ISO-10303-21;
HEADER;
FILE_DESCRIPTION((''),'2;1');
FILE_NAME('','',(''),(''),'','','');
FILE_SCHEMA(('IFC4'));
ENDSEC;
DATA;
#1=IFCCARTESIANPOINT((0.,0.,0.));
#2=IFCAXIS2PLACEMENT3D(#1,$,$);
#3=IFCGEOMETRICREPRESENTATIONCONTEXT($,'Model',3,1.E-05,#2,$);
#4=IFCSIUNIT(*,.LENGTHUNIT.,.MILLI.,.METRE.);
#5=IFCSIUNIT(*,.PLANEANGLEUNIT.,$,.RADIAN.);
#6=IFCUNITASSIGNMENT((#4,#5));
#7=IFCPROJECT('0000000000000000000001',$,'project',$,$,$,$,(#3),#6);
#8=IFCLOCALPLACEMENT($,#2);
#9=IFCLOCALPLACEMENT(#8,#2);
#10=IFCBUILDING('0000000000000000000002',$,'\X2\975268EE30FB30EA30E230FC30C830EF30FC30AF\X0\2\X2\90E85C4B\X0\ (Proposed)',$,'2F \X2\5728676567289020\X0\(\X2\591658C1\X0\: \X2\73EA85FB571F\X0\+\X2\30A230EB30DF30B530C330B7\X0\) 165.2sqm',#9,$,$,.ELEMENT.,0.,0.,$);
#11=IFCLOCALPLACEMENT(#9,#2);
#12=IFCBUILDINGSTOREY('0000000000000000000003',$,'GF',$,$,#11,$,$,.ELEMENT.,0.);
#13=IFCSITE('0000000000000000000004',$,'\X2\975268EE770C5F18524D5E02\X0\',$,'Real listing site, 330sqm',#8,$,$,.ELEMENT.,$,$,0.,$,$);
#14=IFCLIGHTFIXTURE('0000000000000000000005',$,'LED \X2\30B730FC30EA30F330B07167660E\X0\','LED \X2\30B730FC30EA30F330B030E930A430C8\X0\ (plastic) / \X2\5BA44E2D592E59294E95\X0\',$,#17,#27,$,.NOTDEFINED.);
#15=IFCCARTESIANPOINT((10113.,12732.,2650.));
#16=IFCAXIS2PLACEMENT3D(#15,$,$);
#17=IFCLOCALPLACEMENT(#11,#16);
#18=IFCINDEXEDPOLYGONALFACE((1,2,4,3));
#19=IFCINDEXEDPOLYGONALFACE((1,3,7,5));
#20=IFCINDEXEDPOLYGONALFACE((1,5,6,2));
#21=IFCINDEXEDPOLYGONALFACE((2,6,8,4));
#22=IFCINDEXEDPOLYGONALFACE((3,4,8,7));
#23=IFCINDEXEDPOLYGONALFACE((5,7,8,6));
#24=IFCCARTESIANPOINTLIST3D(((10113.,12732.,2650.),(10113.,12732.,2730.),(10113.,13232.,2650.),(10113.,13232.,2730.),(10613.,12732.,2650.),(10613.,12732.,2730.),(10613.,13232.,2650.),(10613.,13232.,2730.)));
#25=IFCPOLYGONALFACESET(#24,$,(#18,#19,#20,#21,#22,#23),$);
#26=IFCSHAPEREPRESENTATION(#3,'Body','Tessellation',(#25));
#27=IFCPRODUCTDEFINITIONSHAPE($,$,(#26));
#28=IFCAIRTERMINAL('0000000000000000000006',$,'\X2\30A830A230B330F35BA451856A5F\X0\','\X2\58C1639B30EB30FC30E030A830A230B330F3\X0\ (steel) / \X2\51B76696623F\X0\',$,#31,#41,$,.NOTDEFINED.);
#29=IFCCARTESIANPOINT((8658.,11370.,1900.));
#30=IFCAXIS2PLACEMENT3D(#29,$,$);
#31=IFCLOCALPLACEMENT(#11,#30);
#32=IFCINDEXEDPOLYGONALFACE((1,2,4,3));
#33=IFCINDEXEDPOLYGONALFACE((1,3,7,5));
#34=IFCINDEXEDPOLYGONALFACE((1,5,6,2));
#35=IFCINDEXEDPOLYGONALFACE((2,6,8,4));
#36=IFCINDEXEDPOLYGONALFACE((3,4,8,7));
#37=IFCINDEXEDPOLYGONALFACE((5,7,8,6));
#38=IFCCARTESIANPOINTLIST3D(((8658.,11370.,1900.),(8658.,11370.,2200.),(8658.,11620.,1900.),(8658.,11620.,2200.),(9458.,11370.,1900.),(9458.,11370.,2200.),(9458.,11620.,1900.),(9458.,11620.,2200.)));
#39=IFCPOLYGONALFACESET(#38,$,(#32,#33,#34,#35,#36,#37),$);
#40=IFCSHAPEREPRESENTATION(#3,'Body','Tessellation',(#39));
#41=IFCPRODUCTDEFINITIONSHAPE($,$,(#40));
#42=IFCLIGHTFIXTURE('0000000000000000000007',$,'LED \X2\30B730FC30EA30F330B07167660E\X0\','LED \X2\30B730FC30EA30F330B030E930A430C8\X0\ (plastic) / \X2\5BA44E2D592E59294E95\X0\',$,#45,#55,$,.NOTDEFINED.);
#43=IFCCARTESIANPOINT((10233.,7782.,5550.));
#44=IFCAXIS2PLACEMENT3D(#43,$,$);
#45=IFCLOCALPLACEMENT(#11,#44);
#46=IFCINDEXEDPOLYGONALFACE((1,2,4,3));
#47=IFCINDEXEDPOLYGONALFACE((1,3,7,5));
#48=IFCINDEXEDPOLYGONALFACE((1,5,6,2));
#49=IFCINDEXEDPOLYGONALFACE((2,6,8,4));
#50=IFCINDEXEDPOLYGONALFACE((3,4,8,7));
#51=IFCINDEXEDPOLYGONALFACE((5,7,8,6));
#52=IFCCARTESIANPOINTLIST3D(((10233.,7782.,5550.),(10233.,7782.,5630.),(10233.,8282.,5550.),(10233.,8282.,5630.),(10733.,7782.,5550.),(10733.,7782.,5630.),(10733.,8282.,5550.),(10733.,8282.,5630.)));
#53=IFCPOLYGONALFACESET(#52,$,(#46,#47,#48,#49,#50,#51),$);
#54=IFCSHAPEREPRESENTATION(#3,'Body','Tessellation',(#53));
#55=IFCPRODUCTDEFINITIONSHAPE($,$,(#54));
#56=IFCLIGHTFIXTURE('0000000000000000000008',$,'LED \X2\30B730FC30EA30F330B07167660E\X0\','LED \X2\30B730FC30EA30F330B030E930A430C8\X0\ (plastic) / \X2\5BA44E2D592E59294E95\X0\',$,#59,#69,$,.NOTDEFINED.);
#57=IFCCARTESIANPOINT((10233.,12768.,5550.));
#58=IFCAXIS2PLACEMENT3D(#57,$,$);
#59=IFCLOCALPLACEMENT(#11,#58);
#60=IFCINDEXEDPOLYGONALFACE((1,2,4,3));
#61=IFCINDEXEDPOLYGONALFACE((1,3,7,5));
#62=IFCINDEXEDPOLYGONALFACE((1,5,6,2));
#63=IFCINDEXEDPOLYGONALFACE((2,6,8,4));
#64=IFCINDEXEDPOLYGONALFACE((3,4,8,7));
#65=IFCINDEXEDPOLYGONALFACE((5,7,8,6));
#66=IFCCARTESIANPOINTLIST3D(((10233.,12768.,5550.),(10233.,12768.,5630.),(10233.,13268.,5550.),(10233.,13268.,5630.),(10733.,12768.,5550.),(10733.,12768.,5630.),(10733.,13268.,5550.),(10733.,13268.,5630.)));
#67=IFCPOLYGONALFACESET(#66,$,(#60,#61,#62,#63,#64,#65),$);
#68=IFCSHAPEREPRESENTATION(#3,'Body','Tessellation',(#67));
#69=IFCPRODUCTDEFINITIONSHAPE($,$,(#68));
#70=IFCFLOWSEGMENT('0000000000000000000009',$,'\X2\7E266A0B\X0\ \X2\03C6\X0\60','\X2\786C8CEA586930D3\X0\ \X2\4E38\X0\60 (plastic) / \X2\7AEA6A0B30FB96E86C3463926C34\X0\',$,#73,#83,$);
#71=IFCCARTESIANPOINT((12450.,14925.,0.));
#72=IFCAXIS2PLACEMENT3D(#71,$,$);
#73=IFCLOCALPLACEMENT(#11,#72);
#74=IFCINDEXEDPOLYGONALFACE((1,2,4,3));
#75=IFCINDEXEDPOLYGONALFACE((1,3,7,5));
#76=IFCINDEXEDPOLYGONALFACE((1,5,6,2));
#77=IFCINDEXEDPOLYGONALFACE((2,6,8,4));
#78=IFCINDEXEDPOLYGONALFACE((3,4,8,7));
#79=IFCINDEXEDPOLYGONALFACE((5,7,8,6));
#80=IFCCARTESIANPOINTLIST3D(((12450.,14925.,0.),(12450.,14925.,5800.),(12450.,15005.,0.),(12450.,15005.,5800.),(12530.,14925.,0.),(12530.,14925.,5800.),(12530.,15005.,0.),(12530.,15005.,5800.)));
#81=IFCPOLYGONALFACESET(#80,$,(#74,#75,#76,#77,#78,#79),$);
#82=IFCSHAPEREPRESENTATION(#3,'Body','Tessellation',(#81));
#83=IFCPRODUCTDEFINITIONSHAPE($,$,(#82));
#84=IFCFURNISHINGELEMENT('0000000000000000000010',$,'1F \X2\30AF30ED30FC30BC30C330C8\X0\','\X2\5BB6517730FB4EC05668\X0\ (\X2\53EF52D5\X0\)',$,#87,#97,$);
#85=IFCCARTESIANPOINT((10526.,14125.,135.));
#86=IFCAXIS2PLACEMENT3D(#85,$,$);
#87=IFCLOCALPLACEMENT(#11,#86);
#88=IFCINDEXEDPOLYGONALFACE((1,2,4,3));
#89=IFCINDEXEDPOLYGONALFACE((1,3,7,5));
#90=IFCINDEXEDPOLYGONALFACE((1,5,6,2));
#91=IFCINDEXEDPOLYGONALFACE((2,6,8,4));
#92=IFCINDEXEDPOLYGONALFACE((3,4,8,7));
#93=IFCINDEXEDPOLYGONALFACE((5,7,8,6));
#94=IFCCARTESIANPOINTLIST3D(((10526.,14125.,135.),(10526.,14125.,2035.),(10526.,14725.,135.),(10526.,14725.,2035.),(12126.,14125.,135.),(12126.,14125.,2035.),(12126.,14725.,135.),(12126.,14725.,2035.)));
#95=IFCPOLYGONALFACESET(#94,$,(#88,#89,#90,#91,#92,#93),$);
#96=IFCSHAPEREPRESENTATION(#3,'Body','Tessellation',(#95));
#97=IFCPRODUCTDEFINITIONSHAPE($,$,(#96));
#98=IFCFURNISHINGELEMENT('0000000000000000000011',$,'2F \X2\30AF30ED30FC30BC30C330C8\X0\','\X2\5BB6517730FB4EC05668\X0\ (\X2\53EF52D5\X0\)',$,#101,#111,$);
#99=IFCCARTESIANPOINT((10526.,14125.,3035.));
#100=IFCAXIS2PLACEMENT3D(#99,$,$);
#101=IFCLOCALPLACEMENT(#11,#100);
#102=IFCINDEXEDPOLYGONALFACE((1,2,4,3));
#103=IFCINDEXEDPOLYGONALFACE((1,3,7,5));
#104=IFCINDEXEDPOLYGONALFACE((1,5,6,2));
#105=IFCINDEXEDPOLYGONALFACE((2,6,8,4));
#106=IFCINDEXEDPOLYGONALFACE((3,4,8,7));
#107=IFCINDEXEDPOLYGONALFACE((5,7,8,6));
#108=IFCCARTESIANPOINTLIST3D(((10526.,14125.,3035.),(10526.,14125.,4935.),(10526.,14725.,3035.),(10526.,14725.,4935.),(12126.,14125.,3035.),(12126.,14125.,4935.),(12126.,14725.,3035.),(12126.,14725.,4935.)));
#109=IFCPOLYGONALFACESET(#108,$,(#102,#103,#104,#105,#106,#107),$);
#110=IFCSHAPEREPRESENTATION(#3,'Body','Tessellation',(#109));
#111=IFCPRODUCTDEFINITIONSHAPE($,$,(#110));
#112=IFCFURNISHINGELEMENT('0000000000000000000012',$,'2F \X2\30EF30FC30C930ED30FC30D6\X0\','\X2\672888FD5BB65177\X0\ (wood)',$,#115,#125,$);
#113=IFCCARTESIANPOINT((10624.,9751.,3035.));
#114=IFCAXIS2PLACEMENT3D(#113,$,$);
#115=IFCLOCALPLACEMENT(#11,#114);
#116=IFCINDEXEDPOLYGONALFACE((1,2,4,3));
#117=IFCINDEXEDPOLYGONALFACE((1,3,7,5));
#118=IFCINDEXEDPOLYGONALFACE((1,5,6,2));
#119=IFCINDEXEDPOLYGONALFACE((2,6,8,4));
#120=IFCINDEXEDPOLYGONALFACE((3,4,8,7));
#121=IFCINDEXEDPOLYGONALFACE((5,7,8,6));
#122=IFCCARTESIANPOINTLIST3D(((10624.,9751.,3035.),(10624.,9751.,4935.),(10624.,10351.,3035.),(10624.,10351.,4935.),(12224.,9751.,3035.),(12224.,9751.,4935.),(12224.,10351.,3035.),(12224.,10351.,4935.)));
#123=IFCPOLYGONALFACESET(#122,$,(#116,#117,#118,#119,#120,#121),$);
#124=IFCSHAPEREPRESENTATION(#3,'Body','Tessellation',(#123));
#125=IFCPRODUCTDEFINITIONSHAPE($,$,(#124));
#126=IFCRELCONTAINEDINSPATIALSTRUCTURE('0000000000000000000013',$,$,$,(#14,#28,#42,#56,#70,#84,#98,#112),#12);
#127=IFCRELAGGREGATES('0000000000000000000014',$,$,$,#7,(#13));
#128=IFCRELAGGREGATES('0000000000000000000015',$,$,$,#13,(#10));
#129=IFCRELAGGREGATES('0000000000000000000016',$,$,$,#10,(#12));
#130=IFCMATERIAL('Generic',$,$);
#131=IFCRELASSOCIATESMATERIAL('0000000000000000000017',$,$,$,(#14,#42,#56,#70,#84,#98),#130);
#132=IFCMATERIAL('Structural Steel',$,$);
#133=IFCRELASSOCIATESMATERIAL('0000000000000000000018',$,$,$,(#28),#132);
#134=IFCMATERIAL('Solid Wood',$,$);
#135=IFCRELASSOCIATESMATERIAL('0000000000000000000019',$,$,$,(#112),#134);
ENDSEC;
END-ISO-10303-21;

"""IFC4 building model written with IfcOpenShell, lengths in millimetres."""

from ifc_helpers import new_model, si_unit, frame, frame_2d, origin, place, context, project, spatial, rectangle, extrude, material, element, save


model = new_model("IFC4")

# Units and contexts
model_context = context("Model", 3, precision=1e-05, world=origin())
ifc_project = project(units=[si_unit("LENGTHUNIT", "METRE", prefix="MILLI"), si_unit("PLANEANGLEUNIT", "RADIAN")], contexts=[model_context])

# Site, building, storey
site_placement = place(None, origin())
site = spatial("IfcSite", under=ifc_project, at=site_placement, Name="青森県弘前市", ObjectType="Real listing site, 330sqm", CompositionType="ELEMENT", RefElevation=0.0)
building_placement = place(site_placement, origin())
building = spatial("IfcBuilding", under=site, at=building_placement, Name="青森・リモートワーク2部屋 (Proposed)", ObjectType="2F 在来木造(外壁: 珪藻土+アルミサッシ) 165.2sqm", CompositionType="ELEMENT", ElevationOfRefHeight=0.0, ElevationOfTerrain=0.0)
storey_placement = place(building_placement, origin())
storey = spatial("IfcBuildingStorey", under=building, at=storey_placement, Name="GF", CompositionType="ELEMENT", Elevation=0.0)

# Shared definitions
ifc_material_1 = material(Name="Solid Wood")
ifc_material_2 = material(Name="Structural Steel")

# Shared definitions
ifc_material_3 = material(Name="Generic")

# Light fixture
light_fixture_1_placement = place(storey_placement, frame((10113.0, 12732.0, 2650.0)))
element("IfcLightFixture", 1, at=light_fixture_1_placement, inside=storey, material=ifc_material_3, Name="LED シーリング照明", Description="LED シーリングライト (plastic) / 室中央天井", PredefinedType="NOTDEFINED", context=model_context, shape_type="SweptSolid", body=[
    extrude(rectangle(XDim=500.0, YDim=500.0, at=frame_2d((250.0, 250.0))), frame((10113.0, 12732.0, 2650.0)), (0.0, 0.0, 1.0), 80.0),
])

# Air terminal
air_terminal_placement = place(storey_placement, frame((8658.0, 11370.0, 1900.0)))
element("IfcAirTerminal", 2, at=air_terminal_placement, inside=storey, material=ifc_material_2, Name="エアコン室内機", Description="壁掛ルームエアコン (steel) / 冷暖房", PredefinedType="NOTDEFINED", context=model_context, shape_type="SweptSolid", body=[
    extrude(rectangle(XDim=800.0, YDim=250.0, at=frame_2d((400.0, 125.0))), frame((8658.0, 11370.0, 1900.0)), (0.0, 0.0, 1.0), 300.0),
])

# Light fixtures
light_fixture_2_placement = place(storey_placement, frame((10233.0, 7782.0, 5550.0)))
element("IfcLightFixture", 3, at=light_fixture_2_placement, inside=storey, material=ifc_material_3, Name="LED シーリング照明", Description="LED シーリングライト (plastic) / 室中央天井", PredefinedType="NOTDEFINED", context=model_context, shape_type="SweptSolid", body=[
    extrude(rectangle(XDim=500.0, YDim=500.0, at=frame_2d((250.0, 250.0))), frame((10233.0, 7782.0, 5550.0)), (0.0, 0.0, 1.0), 80.0),
])
light_fixture_3_placement = place(storey_placement, frame((10233.0, 12768.0, 5550.0)))
element("IfcLightFixture", 4, at=light_fixture_3_placement, inside=storey, material=ifc_material_3, Name="LED シーリング照明", Description="LED シーリングライト (plastic) / 室中央天井", PredefinedType="NOTDEFINED", context=model_context, shape_type="SweptSolid", body=[
    extrude(rectangle(XDim=500.0, YDim=500.0, at=frame_2d((250.0, 250.0))), frame((10233.0, 12768.0, 5550.0)), (0.0, 0.0, 1.0), 80.0),
])

# Flow segment
flow_segment_placement = place(storey_placement, frame((12450.0, 14925.0, 0.0)))
element("IfcFlowSegment", 5, at=flow_segment_placement, inside=storey, material=ifc_material_3, Name="縦樋 φ60", Description="硬質塩ビ 丸60 (plastic) / 竪樋・雨水排水", context=model_context, shape_type="SweptSolid", body=[
    extrude(rectangle(XDim=80.0, YDim=80.0, at=frame_2d((40.0, 40.0))), frame((12450.0, 14925.0, 0.0)), (0.0, 0.0, 1.0), 5800.0),
])

# Furnishing elements
furnishing_1_placement = place(storey_placement, frame((10526.0, 14125.0, 135.0)))
element("IfcFurnishingElement", 6, at=furnishing_1_placement, inside=storey, material=ifc_material_3, Name="1F クローゼット", Description="家具・什器 (可動)", context=model_context, shape_type="SweptSolid", body=[
    extrude(rectangle(XDim=1600.0, YDim=600.0, at=frame_2d((800.0, 300.0))), frame((10526.0, 14125.0, 135.0)), (0.0, 0.0, 1.0), 1900.0),
])
furnishing_2_placement = place(storey_placement, frame((10526.0, 14125.0, 3035.0)))
element("IfcFurnishingElement", 7, at=furnishing_2_placement, inside=storey, material=ifc_material_3, Name="2F クローゼット", Description="家具・什器 (可動)", context=model_context, shape_type="SweptSolid", body=[
    extrude(rectangle(XDim=1600.0, YDim=600.0, at=frame_2d((800.0, 300.0))), frame((10526.0, 14125.0, 3035.0)), (0.0, 0.0, 1.0), 1900.0),
])
furnishing_3_placement = place(storey_placement, frame((10624.0, 9751.0, 3035.0)))
element("IfcFurnishingElement", 8, at=furnishing_3_placement, inside=storey, material=ifc_material_1, Name="2F ワードローブ", Description="木製家具 (wood)", context=model_context, shape_type="SweptSolid", body=[
    extrude(rectangle(XDim=1600.0, YDim=600.0, at=frame_2d((800.0, 300.0))), frame((10624.0, 9751.0, 3035.0)), (0.0, 0.0, 1.0), 1900.0),
])

save(model, "model.ifc")
